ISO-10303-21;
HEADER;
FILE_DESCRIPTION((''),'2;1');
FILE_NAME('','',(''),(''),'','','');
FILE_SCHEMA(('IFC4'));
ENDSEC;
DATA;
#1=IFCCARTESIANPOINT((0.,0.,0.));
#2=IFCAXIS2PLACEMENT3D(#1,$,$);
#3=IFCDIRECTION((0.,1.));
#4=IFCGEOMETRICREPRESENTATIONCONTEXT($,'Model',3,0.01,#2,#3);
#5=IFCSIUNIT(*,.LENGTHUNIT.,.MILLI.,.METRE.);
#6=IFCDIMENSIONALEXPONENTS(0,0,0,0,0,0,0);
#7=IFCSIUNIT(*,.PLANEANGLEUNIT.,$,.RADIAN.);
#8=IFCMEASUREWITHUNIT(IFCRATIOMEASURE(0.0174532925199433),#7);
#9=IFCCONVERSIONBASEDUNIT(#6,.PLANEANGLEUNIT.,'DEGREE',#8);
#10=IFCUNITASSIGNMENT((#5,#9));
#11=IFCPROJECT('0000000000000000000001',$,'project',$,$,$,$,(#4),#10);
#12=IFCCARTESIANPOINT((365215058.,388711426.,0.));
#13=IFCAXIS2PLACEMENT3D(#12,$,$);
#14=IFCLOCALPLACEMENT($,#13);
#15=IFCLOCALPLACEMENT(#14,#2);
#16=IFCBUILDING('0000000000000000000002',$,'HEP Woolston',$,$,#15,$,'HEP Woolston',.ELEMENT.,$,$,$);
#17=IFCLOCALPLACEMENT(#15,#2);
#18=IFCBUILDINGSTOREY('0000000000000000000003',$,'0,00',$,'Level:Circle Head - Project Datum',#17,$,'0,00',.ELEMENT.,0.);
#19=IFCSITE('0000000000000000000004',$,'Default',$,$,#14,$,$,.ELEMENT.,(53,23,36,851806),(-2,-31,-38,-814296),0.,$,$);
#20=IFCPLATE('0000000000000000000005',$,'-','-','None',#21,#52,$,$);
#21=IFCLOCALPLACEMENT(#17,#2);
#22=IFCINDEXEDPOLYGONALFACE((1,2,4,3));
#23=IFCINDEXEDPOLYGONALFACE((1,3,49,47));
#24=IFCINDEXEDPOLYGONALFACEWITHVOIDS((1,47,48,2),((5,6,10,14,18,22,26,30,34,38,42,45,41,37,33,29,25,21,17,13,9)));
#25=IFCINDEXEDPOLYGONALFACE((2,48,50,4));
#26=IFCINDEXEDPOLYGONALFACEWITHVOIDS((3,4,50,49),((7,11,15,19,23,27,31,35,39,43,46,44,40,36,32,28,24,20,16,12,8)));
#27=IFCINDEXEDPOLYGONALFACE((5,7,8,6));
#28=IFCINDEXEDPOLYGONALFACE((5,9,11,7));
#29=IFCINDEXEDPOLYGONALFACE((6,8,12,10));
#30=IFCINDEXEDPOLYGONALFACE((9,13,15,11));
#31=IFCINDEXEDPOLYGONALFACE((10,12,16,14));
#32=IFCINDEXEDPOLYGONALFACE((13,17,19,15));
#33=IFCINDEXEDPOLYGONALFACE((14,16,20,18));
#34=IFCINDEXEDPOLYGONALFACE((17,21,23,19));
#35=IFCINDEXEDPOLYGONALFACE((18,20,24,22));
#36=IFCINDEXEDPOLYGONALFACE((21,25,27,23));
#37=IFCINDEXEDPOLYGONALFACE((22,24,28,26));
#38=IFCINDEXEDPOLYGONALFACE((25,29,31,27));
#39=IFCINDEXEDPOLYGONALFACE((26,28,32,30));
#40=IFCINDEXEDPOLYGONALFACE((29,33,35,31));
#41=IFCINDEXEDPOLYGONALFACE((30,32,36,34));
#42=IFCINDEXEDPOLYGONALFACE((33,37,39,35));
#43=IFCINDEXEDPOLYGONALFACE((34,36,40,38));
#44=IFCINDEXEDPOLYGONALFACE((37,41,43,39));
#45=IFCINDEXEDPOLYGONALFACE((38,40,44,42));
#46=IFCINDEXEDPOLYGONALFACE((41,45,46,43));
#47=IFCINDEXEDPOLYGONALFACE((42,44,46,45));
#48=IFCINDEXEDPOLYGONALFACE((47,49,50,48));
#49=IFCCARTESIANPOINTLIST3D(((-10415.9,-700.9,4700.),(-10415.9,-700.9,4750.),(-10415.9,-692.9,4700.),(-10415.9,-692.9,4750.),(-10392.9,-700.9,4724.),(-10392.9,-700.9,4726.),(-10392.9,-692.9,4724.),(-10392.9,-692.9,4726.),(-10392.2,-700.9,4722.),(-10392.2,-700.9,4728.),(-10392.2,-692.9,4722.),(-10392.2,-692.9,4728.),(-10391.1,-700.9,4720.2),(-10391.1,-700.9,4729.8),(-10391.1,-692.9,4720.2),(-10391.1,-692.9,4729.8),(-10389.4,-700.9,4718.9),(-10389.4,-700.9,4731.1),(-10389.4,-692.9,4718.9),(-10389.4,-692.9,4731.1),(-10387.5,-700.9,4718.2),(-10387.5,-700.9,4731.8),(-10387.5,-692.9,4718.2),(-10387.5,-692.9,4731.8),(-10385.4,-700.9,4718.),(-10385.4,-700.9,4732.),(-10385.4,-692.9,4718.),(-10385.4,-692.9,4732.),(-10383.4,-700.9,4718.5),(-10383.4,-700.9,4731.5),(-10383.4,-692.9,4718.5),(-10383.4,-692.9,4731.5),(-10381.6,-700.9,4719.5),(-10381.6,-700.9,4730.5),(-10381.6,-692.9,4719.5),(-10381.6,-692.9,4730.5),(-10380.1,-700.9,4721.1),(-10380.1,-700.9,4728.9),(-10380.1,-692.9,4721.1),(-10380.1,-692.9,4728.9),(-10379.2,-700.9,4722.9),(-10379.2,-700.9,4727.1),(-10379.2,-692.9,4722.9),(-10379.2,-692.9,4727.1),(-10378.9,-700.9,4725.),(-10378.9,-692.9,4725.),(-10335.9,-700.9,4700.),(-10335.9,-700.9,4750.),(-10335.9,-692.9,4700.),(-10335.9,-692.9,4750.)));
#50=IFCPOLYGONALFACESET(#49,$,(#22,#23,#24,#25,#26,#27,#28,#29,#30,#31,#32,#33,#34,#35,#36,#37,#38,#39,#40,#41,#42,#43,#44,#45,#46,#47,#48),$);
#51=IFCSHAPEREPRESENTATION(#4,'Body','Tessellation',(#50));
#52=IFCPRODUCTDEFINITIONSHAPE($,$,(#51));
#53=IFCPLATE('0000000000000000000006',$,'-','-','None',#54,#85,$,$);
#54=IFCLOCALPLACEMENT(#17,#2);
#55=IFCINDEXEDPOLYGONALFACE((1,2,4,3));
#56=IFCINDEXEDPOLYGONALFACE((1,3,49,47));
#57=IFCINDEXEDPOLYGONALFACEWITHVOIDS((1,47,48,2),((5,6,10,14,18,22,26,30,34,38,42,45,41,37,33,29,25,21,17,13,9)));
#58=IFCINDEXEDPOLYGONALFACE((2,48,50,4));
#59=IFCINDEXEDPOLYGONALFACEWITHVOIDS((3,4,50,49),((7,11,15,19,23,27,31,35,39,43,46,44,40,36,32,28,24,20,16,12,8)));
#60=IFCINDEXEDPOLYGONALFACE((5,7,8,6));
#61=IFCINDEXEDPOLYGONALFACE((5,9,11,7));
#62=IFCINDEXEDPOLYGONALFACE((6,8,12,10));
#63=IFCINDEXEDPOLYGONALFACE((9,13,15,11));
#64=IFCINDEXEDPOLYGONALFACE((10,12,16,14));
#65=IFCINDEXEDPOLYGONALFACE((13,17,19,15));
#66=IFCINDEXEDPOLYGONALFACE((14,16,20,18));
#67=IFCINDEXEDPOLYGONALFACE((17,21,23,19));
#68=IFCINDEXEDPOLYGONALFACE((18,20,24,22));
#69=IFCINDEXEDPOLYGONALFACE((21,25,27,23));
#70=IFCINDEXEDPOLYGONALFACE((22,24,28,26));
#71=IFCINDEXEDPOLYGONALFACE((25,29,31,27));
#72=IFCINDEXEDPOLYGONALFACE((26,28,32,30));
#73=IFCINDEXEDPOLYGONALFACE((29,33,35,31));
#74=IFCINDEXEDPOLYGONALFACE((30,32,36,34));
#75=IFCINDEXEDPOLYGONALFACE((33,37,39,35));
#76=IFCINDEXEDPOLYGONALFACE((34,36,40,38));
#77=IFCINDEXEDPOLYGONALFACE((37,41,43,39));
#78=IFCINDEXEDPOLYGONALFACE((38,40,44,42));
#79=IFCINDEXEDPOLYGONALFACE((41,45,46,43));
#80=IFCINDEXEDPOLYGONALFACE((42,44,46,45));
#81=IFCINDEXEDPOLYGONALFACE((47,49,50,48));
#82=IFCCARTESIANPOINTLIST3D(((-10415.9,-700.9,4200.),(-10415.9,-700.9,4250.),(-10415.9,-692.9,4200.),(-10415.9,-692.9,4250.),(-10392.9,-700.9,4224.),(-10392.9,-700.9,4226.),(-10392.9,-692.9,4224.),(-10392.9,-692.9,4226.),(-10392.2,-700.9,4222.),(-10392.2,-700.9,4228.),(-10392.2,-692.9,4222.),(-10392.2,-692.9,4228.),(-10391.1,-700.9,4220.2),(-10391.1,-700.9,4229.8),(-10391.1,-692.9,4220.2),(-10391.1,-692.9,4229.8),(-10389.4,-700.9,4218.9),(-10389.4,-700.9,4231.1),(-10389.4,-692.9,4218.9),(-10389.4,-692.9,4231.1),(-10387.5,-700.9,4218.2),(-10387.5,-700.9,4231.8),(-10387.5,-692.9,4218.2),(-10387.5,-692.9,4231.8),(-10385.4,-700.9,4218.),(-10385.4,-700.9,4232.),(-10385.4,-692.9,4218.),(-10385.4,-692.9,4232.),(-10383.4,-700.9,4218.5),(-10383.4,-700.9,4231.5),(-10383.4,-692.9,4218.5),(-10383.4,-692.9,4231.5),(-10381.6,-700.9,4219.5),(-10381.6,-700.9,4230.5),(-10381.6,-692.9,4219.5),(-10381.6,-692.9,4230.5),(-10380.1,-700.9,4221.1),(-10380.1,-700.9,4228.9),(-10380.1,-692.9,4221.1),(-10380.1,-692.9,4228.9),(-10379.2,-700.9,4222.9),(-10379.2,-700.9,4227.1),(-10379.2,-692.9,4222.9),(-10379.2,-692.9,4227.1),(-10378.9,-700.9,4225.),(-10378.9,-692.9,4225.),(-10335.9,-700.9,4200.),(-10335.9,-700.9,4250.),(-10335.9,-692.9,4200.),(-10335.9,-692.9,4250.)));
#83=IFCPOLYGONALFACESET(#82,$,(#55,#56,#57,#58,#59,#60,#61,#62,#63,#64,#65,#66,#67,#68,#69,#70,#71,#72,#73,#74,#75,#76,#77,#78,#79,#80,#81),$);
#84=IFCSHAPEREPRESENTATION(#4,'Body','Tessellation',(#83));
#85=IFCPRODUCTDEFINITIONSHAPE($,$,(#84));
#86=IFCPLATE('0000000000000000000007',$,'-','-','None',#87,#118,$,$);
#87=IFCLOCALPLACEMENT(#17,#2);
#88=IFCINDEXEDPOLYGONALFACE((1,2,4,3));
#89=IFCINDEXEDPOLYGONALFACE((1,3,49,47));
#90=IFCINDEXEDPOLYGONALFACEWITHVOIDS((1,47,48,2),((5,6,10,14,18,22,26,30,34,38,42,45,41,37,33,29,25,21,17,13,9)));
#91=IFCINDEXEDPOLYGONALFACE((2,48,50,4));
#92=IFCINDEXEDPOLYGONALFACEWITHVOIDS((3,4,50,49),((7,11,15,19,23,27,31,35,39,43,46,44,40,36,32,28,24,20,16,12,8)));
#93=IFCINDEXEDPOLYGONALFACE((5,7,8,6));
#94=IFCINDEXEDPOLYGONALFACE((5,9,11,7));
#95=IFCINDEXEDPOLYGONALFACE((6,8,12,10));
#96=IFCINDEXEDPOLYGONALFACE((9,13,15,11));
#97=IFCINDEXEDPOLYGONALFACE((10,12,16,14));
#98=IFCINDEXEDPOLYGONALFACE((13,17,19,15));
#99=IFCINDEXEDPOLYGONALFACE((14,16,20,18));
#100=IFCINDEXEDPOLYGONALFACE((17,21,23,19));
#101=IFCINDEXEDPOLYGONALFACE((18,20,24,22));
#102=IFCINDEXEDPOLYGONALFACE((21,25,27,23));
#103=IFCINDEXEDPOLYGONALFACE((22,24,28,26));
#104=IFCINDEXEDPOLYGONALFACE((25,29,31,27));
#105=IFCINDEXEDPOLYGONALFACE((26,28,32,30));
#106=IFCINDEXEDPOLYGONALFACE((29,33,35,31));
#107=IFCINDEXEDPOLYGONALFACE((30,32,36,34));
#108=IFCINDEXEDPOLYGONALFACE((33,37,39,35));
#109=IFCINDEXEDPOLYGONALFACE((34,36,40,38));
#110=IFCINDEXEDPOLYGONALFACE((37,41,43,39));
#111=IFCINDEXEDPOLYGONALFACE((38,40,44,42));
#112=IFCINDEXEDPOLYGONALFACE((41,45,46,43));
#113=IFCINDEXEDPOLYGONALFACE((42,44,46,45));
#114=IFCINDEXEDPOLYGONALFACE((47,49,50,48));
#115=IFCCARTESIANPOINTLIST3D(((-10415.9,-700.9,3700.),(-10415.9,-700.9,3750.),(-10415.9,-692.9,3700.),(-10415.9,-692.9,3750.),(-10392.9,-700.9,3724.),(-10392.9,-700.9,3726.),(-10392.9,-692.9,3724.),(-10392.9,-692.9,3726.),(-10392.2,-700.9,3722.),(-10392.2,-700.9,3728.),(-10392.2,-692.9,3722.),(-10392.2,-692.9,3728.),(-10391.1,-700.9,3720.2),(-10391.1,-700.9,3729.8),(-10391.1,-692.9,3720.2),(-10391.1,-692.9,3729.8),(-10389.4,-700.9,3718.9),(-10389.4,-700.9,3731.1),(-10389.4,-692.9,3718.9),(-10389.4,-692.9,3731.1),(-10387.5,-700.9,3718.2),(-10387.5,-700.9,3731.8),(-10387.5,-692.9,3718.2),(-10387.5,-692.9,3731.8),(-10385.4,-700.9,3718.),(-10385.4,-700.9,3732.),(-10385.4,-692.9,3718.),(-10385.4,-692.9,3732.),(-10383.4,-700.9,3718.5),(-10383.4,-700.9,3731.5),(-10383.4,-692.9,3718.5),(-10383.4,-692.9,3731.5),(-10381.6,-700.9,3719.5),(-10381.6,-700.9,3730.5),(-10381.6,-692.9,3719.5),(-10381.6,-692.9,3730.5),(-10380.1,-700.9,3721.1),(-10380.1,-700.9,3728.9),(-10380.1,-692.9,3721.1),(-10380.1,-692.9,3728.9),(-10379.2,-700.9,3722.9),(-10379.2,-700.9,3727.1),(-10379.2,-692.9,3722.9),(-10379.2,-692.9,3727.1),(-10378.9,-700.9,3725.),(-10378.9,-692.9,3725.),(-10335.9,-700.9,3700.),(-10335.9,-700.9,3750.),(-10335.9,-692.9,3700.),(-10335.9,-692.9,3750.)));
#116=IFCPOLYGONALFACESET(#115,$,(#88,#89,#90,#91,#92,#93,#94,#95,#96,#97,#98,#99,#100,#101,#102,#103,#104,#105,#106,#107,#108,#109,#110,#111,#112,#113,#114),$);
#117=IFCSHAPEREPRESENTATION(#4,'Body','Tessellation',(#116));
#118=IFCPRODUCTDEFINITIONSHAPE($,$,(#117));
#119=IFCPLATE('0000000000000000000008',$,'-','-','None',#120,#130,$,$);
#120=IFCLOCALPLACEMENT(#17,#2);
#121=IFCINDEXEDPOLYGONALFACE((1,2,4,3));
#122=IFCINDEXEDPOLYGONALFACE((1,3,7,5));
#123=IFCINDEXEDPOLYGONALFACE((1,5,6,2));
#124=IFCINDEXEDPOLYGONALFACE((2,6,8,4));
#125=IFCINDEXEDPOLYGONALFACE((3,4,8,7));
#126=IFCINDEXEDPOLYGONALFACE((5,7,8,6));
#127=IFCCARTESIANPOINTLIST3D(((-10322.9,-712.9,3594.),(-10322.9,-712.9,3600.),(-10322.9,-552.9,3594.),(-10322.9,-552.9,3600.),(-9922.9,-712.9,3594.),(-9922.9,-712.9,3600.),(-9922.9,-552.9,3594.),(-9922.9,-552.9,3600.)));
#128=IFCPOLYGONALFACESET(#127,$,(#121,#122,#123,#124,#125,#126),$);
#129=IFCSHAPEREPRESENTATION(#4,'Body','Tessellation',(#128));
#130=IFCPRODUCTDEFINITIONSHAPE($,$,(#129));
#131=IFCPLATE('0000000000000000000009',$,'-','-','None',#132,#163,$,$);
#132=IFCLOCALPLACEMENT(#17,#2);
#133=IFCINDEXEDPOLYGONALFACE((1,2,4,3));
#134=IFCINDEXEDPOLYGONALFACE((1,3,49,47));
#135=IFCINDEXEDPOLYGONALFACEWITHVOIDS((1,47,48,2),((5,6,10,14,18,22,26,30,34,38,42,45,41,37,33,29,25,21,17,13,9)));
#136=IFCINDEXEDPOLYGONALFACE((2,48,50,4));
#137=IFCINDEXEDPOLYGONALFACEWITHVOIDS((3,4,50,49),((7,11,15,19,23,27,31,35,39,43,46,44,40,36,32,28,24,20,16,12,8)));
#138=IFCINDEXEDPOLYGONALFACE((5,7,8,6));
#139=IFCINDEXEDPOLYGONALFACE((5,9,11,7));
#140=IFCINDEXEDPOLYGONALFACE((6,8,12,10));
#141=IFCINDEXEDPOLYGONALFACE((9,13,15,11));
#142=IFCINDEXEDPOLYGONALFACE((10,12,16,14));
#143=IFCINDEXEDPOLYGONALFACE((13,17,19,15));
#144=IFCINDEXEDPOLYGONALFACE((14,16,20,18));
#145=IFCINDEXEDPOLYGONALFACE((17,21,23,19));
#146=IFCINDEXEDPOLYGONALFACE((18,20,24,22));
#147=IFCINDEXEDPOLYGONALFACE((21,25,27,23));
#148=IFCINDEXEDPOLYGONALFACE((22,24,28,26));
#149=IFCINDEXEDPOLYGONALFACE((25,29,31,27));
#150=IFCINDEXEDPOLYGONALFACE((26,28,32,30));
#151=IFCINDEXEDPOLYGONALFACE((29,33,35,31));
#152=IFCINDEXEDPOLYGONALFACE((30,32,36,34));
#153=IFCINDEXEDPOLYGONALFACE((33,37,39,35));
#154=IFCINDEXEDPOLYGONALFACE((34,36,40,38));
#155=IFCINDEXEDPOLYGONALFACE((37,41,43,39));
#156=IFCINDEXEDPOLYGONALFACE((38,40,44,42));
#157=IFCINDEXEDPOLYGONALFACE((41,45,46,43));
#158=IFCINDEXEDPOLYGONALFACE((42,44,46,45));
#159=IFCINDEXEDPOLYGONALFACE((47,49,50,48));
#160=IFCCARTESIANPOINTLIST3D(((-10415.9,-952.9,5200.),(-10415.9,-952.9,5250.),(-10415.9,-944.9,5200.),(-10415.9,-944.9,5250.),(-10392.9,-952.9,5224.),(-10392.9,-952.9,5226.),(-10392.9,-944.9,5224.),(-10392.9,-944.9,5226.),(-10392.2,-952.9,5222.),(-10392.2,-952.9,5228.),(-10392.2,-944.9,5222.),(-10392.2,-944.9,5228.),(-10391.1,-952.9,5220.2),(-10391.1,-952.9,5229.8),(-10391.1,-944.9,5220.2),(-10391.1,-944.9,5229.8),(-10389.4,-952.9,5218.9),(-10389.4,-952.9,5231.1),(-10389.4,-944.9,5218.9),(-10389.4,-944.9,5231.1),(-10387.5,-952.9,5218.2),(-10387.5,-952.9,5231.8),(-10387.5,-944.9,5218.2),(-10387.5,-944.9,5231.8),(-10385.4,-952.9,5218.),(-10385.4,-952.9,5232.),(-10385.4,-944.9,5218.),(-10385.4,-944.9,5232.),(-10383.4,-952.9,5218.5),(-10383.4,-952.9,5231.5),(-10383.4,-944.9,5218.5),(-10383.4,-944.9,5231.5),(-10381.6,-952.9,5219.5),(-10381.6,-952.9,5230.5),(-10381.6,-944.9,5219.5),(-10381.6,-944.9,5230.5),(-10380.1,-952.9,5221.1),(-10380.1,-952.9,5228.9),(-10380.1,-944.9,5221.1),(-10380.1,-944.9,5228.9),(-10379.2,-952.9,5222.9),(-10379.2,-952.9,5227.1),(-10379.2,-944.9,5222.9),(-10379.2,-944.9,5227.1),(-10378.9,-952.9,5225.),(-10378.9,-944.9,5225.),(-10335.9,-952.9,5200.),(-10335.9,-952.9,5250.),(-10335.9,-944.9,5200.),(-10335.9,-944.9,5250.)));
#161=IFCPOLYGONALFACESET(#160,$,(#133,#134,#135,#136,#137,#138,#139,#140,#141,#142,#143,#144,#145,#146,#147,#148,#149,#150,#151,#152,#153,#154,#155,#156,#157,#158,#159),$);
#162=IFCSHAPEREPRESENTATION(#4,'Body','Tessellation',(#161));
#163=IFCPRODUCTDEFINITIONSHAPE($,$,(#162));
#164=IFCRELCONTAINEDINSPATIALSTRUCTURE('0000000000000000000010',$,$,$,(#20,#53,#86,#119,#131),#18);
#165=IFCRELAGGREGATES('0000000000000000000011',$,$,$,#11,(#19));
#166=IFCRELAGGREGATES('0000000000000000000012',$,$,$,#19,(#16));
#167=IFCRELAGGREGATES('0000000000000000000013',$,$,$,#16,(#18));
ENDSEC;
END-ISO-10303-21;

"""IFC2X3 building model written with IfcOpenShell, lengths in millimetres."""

from ifc_helpers import new_model, entity, si_unit, converted_unit, direction, frame, frame_2d, origin, origin_with_axes, origin_2d_with_axis, place, context, project, spatial, polyline, circle, outline, extrude, element, save


model = new_model("IFC2X3")

# Units and contexts
model_context = context("Model", 3, precision=0.01, world=origin(), true_north=direction((0.0, 1.0)))
ifc_project = project(units=[si_unit("LENGTHUNIT", "METRE", prefix="MILLI"), converted_unit("PLANEANGLEUNIT", "DEGREE", entity("IfcRatioMeasure", 0.0174532925199433), si_unit("PLANEANGLEUNIT", "RADIAN"), dimensions=[0, 0, 0, 0, 0, 0, 0])], contexts=[model_context])

# Site, building, storey
site_placement = place(None, frame((365215058.0, 388711426.0, 0.0)))
site = spatial("IfcSite", under=ifc_project, at=site_placement, Name="Default", CompositionType="ELEMENT", RefLatitude=(53, 23, 36, 851806), RefLongitude=(-2, -31, -38, -814296), RefElevation=0.0)
building_placement = place(site_placement, origin())
building = spatial("IfcBuilding", under=site, at=building_placement, Name="HEP Woolston", LongName="HEP Woolston", CompositionType="ELEMENT")
storey_placement = place(building_placement, origin())
storey = spatial("IfcBuildingStorey", under=building, at=storey_placement, Name="0,00", ObjectType="Level:Circle Head - Project Datum", LongName="0,00", CompositionType="ELEMENT", Elevation=0.0)

# Plates, openings
plate_1_placement = place(storey_placement, frame((-10335.9, -692.9, 4750.0), z_axis=(0.0, 1.0, 0.0), x_axis=(-1.0, 0.0, 0.0)))
plate_1 = element("IfcPlate", 1, at=plate_1_placement, inside=storey, Name="-", Description="-", ObjectType="None", context=model_context, shape_type="SweptSolid", body=[
    extrude(outline(polyline([(0.0, 0.0), (0.0, -50.0), (80.0, -50.0), (80.0, 0.0), (0.0, 0.0)])), origin_with_axes(), (0.0, 0.0, -1.0), 8.0),
])
opening_1_placement = place(plate_1_placement, frame((57.0, -25.0, -8.5), z_axis=(0.0, 0.0, -1.0), x_axis=(-1.0, 0.0, 0.0)))
element("IfcOpeningElement", 2, at=opening_1_placement, cuts=plate_1, ObjectType="Opening", context=model_context, shape_type="SweptSolid", body=[
    extrude(circle(Radius=7.0, at=frame_2d((7.0, 0.0), x_axis=(1.0, 0.0))), origin(), (0.0, 0.0, -1.0), 9.0),
])
plate_2_placement = place(storey_placement, frame((-10335.9, -692.9, 4250.0), z_axis=(0.0, 1.0, 0.0), x_axis=(-1.0, 0.0, 0.0)))
plate_2 = element("IfcPlate", 3, at=plate_2_placement, inside=storey, Name="-", Description="-", ObjectType="None", context=model_context, shape_type="SweptSolid", body=[
    extrude(outline(polyline([(0.0, 0.0), (0.0, -50.0), (80.0, -50.0), (80.0, 0.0), (0.0, 0.0)])), origin_with_axes(), (0.0, 0.0, -1.0), 8.0),
])
opening_2_placement = place(plate_2_placement, frame((57.0, -25.0, -8.5), z_axis=(0.0, 0.0, -1.0), x_axis=(-1.0, 0.0, 0.0)))
element("IfcOpeningElement", 4, at=opening_2_placement, cuts=plate_2, ObjectType="Opening", context=model_context, shape_type="SweptSolid", body=[
    extrude(circle(Radius=7.0, at=frame_2d((7.0, 0.0), x_axis=(1.0, 0.0))), origin(), (0.0, 0.0, -1.0), 9.0),
])
plate_3_placement = place(storey_placement, frame((-10335.9, -692.9, 3750.0), z_axis=(0.0, 1.0, 0.0), x_axis=(-1.0, 0.0, 0.0)))
plate_3 = element("IfcPlate", 5, at=plate_3_placement, inside=storey, Name="-", Description="-", ObjectType="None", context=model_context, shape_type="SweptSolid", body=[
    extrude(outline(polyline([(0.0, 0.0), (0.0, -50.0), (80.0, -50.0), (80.0, 0.0), (0.0, 0.0)])), origin_with_axes(), (0.0, 0.0, -1.0), 8.0),
])
opening_3_placement = place(plate_3_placement, frame((57.0, -25.0, -8.5), z_axis=(0.0, 0.0, -1.0), x_axis=(-1.0, 0.0, 0.0)))
element("IfcOpeningElement", 6, at=opening_3_placement, cuts=plate_3, ObjectType="Opening", context=model_context, shape_type="SweptSolid", body=[
    extrude(circle(Radius=7.0, at=frame_2d((7.0, 0.0), x_axis=(1.0, 0.0))), origin(), (0.0, 0.0, -1.0), 9.0),
])

# Plate
plate_4_placement = place(storey_placement, frame((-10322.9, -712.9, 3594.0)))
element("IfcPlate", 7, at=plate_4_placement, inside=storey, Name="-", Description="-", ObjectType="None", context=model_context, shape_type="SweptSolid", body=[
    extrude(outline(polyline([(0.0, 0.0), (400.0, 0.0), (400.0, 160.0), (0.0, 160.0), (0.0, 0.0)])), origin_with_axes(), (0.0, 0.0, 1.0), 6.0),
])

# Plate, opening
plate_5_placement = place(storey_placement, frame((-10335.9, -952.9, 5250.0), z_axis=(0.0, 1.0, 0.0), x_axis=(-1.0, 0.0, 0.0)))
plate_5 = element("IfcPlate", 8, at=plate_5_placement, inside=storey, Name="-", Description="-", ObjectType="None", context=model_context, shape_type="SweptSolid", body=[
    extrude(outline(polyline([(0.0, 0.0), (0.0, -50.0), (80.0, -50.0), (80.0, 0.0), (0.0, 0.0)])), origin_with_axes(), (0.0, 0.0, 1.0), 8.0),
])
opening_4_placement = place(plate_5_placement, frame((50.0, -25.0, 8.5), z_axis=(0.0, 0.0, -1.0), x_axis=(-1.0, 0.0, 0.0)))
element("IfcOpeningElement", 9, at=opening_4_placement, cuts=plate_5, ObjectType="Opening", context=model_context, shape_type="SweptSolid", body=[
    extrude(circle(Radius=7.0, at=origin_2d_with_axis()), origin(), (0.0, 0.0, 1.0), 9.0),
])

save(model, "model.ifc")
